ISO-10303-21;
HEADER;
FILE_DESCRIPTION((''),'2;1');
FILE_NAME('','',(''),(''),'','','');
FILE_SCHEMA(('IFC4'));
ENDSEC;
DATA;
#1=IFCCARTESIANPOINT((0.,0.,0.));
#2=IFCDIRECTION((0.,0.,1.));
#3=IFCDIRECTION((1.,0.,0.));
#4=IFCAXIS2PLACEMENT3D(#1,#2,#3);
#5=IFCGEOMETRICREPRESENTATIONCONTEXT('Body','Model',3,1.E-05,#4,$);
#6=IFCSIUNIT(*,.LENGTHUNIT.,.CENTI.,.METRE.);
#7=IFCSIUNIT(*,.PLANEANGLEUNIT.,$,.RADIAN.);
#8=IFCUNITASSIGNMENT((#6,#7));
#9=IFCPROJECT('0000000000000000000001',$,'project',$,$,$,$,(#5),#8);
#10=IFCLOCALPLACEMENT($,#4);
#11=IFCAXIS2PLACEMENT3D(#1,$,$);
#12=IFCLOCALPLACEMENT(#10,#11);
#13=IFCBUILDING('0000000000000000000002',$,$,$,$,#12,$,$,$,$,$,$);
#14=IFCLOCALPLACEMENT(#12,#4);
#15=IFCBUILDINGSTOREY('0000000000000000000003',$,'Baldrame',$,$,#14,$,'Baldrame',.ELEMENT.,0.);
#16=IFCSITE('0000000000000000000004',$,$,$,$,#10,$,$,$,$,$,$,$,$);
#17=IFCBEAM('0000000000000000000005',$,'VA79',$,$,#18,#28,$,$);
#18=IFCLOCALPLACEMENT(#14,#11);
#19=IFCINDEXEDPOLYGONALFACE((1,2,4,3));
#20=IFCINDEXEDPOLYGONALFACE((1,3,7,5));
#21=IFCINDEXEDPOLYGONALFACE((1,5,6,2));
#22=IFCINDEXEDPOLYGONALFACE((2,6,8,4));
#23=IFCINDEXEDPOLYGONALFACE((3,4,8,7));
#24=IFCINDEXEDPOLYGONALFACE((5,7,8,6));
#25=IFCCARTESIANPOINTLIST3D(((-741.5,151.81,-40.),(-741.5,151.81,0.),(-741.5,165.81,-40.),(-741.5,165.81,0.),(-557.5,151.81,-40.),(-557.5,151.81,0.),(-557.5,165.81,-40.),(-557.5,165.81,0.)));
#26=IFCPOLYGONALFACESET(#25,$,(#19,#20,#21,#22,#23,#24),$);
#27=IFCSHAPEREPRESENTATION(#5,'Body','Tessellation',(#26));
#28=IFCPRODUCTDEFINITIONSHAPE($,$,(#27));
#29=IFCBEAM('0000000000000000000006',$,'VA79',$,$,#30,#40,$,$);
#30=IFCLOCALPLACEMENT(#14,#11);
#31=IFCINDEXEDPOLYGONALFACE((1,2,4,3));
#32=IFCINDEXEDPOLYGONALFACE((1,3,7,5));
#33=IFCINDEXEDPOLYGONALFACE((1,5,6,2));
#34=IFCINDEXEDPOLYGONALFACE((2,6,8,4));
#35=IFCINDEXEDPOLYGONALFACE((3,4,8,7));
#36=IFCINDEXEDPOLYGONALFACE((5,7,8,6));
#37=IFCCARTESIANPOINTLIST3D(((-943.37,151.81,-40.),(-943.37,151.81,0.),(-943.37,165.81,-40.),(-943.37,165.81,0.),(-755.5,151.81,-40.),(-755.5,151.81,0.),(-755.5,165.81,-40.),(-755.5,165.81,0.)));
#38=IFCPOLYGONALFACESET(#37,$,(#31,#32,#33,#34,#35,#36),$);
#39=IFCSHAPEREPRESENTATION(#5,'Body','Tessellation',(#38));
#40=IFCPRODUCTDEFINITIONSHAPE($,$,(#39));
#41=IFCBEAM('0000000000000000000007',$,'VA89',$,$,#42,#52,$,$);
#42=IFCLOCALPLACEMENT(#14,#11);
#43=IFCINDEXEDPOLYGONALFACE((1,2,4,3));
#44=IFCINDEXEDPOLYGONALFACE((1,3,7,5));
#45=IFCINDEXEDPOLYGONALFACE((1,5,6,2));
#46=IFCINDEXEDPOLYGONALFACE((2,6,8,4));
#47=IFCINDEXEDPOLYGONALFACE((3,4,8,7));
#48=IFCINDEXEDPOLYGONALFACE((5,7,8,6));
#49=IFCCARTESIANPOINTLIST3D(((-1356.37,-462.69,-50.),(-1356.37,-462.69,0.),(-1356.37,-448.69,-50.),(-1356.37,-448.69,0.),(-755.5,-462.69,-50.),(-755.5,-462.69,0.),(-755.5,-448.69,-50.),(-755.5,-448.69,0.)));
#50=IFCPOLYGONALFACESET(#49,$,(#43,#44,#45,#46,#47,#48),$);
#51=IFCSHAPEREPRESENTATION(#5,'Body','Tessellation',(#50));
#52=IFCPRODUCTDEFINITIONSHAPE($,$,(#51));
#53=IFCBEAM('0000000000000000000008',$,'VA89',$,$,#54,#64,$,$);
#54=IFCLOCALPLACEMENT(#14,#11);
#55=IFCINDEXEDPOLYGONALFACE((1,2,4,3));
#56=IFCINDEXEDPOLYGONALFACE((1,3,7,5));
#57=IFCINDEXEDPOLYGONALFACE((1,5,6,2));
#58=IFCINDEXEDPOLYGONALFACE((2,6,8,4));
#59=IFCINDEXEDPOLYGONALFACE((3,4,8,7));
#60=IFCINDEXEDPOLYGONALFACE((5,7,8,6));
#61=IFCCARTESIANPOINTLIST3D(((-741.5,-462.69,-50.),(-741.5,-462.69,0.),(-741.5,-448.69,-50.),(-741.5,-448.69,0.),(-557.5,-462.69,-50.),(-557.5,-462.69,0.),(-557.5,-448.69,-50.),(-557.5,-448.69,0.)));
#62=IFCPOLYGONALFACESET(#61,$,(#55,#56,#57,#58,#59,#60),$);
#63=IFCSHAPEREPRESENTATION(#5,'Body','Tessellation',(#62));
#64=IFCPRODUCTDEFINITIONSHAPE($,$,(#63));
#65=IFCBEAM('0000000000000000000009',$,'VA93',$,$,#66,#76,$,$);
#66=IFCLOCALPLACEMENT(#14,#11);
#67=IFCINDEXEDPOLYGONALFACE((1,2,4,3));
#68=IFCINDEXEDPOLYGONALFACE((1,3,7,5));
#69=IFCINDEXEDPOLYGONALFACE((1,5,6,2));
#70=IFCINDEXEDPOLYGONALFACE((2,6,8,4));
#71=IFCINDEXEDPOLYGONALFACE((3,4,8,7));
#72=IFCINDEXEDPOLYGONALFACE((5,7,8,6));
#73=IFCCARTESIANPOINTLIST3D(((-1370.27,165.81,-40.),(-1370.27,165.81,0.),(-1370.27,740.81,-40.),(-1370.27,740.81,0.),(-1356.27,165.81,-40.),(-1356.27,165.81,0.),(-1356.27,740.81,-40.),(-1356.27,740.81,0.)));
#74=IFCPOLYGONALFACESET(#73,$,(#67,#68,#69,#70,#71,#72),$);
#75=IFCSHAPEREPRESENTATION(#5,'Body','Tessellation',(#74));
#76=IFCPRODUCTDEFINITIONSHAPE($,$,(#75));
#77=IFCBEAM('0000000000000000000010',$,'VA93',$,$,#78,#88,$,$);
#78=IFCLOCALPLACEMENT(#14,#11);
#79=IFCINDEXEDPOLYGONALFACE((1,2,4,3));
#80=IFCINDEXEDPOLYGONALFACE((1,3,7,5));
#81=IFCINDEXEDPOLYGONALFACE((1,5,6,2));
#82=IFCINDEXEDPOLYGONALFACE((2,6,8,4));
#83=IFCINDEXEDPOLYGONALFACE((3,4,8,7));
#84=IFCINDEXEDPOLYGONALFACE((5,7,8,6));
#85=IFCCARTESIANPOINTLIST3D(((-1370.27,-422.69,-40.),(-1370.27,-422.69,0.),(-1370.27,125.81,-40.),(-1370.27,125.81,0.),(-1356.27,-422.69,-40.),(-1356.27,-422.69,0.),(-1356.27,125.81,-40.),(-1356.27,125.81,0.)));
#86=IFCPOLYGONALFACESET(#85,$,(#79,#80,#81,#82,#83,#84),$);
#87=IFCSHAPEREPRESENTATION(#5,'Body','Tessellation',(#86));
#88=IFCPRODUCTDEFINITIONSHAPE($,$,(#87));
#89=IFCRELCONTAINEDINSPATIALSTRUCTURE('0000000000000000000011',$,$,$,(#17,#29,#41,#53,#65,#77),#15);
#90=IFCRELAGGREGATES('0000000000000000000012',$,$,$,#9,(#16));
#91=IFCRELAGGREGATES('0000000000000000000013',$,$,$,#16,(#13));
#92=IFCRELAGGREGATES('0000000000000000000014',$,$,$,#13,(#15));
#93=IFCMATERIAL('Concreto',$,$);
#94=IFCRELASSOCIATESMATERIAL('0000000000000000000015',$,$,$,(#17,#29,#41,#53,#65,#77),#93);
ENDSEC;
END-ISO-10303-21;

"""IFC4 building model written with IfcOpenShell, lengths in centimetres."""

from ifc_helpers import new_model, si_unit, frame, origin, origin_with_axes, origin_2d_with_axis, place, context, project, spatial, rectangle, extrude, material, element, save


model = new_model("IFC4")

# Units and contexts
model_context = context("Model", 3, precision=1e-05, world=origin_with_axes(), identifier="Body")
ifc_project = project(units=[si_unit("LENGTHUNIT", "METRE", prefix="CENTI"), si_unit("PLANEANGLEUNIT", "RADIAN")], contexts=[model_context])

# Site, building, storey
site_placement = place(None, origin_with_axes())
site = spatial("IfcSite", under=ifc_project, at=site_placement)
building_placement = place(site_placement, origin())
building = spatial("IfcBuilding", under=site, at=building_placement)
storey_placement = place(building_placement, origin_with_axes())
storey = spatial("IfcBuildingStorey", under=building, at=storey_placement, Name="Baldrame", LongName="Baldrame", CompositionType="ELEMENT", Elevation=0.0)

# Shared definitions
ifc_material = material(Name="Concreto")

# Beams
beam_1_placement = place(storey_placement, frame((-649.5, 158.81, 0.0), z_axis=(0.0, 0.0, 1.0), x_axis=(1.0, 0.0, 0.0)))
element("IfcBeam", 1, at=beam_1_placement, inside=storey, material=ifc_material, Name="VA79", context=model_context, shape_type="SolidModel", body=[
    extrude(rectangle(XDim=14.0, YDim=40.0, at=origin_2d_with_axis()), frame((-92.0, 0.0, -20.0), z_axis=(1.0, 0.0, 0.0), x_axis=(0.0, -1.0, 0.0)), (0.0, 0.0, 1.0), 184.0),
])
beam_2_placement = place(storey_placement, frame((-849.43, 158.81, 0.0), z_axis=(0.0, 0.0, 1.0), x_axis=(1.0, 0.0, 0.0)))
element("IfcBeam", 2, at=beam_2_placement, inside=storey, material=ifc_material, Name="VA79", context=model_context, shape_type="SolidModel", body=[
    extrude(rectangle(XDim=14.0, YDim=40.0, at=origin_2d_with_axis()), frame((-93.94, 0.0, -20.0), z_axis=(1.0, 0.0, 0.0), x_axis=(0.0, -1.0, 0.0)), (0.0, 0.0, 1.0), 187.87),
])
beam_3_placement = place(storey_placement, frame((-1055.93, -455.69, 0.0), z_axis=(0.0, 0.0, 1.0), x_axis=(1.0, 0.0, 0.0)))
element("IfcBeam", 3, at=beam_3_placement, inside=storey, material=ifc_material, Name="VA89", context=model_context, shape_type="SolidModel", body=[
    extrude(rectangle(XDim=14.0, YDim=50.0, at=origin_2d_with_axis()), frame((-300.44, 0.0, -25.0), z_axis=(1.0, 0.0, 0.0), x_axis=(0.0, -1.0, 0.0)), (0.0, 0.0, 1.0), 600.87),
])
beam_4_placement = place(storey_placement, frame((-649.5, -455.69, 0.0), z_axis=(0.0, 0.0, 1.0), x_axis=(1.0, 0.0, 0.0)))
element("IfcBeam", 4, at=beam_4_placement, inside=storey, material=ifc_material, Name="VA89", context=model_context, shape_type="SolidModel", body=[
    extrude(rectangle(XDim=14.0, YDim=50.0, at=origin_2d_with_axis()), frame((-92.0, 0.0, -25.0), z_axis=(1.0, 0.0, 0.0), x_axis=(0.0, -1.0, 0.0)), (0.0, 0.0, 1.0), 184.0),
])
beam_5_placement = place(storey_placement, frame((-1363.27, 453.31, 0.0), z_axis=(0.0, 0.0, 1.0), x_axis=(1.0, 0.0, 0.0)))
element("IfcBeam", 5, at=beam_5_placement, inside=storey, material=ifc_material, Name="VA93", context=model_context, shape_type="SolidModel", body=[
    extrude(rectangle(XDim=14.0, YDim=40.0, at=origin_2d_with_axis()), frame((0.0, -287.5, -20.0), z_axis=(0.0, 1.0, 0.0), x_axis=(-1.0, 0.0, 0.0)), (0.0, 0.0, 1.0), 575.0),
])
beam_6_placement = place(storey_placement, frame((-1363.27, -148.44, 0.0), z_axis=(0.0, 0.0, 1.0), x_axis=(1.0, 0.0, 0.0)))
element("IfcBeam", 6, at=beam_6_placement, inside=storey, material=ifc_material, Name="VA93", context=model_context, shape_type="SolidModel", body=[
    extrude(rectangle(XDim=14.0, YDim=40.0, at=origin_2d_with_axis()), frame((0.0, -274.25, -20.0), z_axis=(0.0, 1.0, 0.0), x_axis=(-1.0, 0.0, 0.0)), (0.0, 0.0, 1.0), 548.5),
])

save(model, "model.ifc")
